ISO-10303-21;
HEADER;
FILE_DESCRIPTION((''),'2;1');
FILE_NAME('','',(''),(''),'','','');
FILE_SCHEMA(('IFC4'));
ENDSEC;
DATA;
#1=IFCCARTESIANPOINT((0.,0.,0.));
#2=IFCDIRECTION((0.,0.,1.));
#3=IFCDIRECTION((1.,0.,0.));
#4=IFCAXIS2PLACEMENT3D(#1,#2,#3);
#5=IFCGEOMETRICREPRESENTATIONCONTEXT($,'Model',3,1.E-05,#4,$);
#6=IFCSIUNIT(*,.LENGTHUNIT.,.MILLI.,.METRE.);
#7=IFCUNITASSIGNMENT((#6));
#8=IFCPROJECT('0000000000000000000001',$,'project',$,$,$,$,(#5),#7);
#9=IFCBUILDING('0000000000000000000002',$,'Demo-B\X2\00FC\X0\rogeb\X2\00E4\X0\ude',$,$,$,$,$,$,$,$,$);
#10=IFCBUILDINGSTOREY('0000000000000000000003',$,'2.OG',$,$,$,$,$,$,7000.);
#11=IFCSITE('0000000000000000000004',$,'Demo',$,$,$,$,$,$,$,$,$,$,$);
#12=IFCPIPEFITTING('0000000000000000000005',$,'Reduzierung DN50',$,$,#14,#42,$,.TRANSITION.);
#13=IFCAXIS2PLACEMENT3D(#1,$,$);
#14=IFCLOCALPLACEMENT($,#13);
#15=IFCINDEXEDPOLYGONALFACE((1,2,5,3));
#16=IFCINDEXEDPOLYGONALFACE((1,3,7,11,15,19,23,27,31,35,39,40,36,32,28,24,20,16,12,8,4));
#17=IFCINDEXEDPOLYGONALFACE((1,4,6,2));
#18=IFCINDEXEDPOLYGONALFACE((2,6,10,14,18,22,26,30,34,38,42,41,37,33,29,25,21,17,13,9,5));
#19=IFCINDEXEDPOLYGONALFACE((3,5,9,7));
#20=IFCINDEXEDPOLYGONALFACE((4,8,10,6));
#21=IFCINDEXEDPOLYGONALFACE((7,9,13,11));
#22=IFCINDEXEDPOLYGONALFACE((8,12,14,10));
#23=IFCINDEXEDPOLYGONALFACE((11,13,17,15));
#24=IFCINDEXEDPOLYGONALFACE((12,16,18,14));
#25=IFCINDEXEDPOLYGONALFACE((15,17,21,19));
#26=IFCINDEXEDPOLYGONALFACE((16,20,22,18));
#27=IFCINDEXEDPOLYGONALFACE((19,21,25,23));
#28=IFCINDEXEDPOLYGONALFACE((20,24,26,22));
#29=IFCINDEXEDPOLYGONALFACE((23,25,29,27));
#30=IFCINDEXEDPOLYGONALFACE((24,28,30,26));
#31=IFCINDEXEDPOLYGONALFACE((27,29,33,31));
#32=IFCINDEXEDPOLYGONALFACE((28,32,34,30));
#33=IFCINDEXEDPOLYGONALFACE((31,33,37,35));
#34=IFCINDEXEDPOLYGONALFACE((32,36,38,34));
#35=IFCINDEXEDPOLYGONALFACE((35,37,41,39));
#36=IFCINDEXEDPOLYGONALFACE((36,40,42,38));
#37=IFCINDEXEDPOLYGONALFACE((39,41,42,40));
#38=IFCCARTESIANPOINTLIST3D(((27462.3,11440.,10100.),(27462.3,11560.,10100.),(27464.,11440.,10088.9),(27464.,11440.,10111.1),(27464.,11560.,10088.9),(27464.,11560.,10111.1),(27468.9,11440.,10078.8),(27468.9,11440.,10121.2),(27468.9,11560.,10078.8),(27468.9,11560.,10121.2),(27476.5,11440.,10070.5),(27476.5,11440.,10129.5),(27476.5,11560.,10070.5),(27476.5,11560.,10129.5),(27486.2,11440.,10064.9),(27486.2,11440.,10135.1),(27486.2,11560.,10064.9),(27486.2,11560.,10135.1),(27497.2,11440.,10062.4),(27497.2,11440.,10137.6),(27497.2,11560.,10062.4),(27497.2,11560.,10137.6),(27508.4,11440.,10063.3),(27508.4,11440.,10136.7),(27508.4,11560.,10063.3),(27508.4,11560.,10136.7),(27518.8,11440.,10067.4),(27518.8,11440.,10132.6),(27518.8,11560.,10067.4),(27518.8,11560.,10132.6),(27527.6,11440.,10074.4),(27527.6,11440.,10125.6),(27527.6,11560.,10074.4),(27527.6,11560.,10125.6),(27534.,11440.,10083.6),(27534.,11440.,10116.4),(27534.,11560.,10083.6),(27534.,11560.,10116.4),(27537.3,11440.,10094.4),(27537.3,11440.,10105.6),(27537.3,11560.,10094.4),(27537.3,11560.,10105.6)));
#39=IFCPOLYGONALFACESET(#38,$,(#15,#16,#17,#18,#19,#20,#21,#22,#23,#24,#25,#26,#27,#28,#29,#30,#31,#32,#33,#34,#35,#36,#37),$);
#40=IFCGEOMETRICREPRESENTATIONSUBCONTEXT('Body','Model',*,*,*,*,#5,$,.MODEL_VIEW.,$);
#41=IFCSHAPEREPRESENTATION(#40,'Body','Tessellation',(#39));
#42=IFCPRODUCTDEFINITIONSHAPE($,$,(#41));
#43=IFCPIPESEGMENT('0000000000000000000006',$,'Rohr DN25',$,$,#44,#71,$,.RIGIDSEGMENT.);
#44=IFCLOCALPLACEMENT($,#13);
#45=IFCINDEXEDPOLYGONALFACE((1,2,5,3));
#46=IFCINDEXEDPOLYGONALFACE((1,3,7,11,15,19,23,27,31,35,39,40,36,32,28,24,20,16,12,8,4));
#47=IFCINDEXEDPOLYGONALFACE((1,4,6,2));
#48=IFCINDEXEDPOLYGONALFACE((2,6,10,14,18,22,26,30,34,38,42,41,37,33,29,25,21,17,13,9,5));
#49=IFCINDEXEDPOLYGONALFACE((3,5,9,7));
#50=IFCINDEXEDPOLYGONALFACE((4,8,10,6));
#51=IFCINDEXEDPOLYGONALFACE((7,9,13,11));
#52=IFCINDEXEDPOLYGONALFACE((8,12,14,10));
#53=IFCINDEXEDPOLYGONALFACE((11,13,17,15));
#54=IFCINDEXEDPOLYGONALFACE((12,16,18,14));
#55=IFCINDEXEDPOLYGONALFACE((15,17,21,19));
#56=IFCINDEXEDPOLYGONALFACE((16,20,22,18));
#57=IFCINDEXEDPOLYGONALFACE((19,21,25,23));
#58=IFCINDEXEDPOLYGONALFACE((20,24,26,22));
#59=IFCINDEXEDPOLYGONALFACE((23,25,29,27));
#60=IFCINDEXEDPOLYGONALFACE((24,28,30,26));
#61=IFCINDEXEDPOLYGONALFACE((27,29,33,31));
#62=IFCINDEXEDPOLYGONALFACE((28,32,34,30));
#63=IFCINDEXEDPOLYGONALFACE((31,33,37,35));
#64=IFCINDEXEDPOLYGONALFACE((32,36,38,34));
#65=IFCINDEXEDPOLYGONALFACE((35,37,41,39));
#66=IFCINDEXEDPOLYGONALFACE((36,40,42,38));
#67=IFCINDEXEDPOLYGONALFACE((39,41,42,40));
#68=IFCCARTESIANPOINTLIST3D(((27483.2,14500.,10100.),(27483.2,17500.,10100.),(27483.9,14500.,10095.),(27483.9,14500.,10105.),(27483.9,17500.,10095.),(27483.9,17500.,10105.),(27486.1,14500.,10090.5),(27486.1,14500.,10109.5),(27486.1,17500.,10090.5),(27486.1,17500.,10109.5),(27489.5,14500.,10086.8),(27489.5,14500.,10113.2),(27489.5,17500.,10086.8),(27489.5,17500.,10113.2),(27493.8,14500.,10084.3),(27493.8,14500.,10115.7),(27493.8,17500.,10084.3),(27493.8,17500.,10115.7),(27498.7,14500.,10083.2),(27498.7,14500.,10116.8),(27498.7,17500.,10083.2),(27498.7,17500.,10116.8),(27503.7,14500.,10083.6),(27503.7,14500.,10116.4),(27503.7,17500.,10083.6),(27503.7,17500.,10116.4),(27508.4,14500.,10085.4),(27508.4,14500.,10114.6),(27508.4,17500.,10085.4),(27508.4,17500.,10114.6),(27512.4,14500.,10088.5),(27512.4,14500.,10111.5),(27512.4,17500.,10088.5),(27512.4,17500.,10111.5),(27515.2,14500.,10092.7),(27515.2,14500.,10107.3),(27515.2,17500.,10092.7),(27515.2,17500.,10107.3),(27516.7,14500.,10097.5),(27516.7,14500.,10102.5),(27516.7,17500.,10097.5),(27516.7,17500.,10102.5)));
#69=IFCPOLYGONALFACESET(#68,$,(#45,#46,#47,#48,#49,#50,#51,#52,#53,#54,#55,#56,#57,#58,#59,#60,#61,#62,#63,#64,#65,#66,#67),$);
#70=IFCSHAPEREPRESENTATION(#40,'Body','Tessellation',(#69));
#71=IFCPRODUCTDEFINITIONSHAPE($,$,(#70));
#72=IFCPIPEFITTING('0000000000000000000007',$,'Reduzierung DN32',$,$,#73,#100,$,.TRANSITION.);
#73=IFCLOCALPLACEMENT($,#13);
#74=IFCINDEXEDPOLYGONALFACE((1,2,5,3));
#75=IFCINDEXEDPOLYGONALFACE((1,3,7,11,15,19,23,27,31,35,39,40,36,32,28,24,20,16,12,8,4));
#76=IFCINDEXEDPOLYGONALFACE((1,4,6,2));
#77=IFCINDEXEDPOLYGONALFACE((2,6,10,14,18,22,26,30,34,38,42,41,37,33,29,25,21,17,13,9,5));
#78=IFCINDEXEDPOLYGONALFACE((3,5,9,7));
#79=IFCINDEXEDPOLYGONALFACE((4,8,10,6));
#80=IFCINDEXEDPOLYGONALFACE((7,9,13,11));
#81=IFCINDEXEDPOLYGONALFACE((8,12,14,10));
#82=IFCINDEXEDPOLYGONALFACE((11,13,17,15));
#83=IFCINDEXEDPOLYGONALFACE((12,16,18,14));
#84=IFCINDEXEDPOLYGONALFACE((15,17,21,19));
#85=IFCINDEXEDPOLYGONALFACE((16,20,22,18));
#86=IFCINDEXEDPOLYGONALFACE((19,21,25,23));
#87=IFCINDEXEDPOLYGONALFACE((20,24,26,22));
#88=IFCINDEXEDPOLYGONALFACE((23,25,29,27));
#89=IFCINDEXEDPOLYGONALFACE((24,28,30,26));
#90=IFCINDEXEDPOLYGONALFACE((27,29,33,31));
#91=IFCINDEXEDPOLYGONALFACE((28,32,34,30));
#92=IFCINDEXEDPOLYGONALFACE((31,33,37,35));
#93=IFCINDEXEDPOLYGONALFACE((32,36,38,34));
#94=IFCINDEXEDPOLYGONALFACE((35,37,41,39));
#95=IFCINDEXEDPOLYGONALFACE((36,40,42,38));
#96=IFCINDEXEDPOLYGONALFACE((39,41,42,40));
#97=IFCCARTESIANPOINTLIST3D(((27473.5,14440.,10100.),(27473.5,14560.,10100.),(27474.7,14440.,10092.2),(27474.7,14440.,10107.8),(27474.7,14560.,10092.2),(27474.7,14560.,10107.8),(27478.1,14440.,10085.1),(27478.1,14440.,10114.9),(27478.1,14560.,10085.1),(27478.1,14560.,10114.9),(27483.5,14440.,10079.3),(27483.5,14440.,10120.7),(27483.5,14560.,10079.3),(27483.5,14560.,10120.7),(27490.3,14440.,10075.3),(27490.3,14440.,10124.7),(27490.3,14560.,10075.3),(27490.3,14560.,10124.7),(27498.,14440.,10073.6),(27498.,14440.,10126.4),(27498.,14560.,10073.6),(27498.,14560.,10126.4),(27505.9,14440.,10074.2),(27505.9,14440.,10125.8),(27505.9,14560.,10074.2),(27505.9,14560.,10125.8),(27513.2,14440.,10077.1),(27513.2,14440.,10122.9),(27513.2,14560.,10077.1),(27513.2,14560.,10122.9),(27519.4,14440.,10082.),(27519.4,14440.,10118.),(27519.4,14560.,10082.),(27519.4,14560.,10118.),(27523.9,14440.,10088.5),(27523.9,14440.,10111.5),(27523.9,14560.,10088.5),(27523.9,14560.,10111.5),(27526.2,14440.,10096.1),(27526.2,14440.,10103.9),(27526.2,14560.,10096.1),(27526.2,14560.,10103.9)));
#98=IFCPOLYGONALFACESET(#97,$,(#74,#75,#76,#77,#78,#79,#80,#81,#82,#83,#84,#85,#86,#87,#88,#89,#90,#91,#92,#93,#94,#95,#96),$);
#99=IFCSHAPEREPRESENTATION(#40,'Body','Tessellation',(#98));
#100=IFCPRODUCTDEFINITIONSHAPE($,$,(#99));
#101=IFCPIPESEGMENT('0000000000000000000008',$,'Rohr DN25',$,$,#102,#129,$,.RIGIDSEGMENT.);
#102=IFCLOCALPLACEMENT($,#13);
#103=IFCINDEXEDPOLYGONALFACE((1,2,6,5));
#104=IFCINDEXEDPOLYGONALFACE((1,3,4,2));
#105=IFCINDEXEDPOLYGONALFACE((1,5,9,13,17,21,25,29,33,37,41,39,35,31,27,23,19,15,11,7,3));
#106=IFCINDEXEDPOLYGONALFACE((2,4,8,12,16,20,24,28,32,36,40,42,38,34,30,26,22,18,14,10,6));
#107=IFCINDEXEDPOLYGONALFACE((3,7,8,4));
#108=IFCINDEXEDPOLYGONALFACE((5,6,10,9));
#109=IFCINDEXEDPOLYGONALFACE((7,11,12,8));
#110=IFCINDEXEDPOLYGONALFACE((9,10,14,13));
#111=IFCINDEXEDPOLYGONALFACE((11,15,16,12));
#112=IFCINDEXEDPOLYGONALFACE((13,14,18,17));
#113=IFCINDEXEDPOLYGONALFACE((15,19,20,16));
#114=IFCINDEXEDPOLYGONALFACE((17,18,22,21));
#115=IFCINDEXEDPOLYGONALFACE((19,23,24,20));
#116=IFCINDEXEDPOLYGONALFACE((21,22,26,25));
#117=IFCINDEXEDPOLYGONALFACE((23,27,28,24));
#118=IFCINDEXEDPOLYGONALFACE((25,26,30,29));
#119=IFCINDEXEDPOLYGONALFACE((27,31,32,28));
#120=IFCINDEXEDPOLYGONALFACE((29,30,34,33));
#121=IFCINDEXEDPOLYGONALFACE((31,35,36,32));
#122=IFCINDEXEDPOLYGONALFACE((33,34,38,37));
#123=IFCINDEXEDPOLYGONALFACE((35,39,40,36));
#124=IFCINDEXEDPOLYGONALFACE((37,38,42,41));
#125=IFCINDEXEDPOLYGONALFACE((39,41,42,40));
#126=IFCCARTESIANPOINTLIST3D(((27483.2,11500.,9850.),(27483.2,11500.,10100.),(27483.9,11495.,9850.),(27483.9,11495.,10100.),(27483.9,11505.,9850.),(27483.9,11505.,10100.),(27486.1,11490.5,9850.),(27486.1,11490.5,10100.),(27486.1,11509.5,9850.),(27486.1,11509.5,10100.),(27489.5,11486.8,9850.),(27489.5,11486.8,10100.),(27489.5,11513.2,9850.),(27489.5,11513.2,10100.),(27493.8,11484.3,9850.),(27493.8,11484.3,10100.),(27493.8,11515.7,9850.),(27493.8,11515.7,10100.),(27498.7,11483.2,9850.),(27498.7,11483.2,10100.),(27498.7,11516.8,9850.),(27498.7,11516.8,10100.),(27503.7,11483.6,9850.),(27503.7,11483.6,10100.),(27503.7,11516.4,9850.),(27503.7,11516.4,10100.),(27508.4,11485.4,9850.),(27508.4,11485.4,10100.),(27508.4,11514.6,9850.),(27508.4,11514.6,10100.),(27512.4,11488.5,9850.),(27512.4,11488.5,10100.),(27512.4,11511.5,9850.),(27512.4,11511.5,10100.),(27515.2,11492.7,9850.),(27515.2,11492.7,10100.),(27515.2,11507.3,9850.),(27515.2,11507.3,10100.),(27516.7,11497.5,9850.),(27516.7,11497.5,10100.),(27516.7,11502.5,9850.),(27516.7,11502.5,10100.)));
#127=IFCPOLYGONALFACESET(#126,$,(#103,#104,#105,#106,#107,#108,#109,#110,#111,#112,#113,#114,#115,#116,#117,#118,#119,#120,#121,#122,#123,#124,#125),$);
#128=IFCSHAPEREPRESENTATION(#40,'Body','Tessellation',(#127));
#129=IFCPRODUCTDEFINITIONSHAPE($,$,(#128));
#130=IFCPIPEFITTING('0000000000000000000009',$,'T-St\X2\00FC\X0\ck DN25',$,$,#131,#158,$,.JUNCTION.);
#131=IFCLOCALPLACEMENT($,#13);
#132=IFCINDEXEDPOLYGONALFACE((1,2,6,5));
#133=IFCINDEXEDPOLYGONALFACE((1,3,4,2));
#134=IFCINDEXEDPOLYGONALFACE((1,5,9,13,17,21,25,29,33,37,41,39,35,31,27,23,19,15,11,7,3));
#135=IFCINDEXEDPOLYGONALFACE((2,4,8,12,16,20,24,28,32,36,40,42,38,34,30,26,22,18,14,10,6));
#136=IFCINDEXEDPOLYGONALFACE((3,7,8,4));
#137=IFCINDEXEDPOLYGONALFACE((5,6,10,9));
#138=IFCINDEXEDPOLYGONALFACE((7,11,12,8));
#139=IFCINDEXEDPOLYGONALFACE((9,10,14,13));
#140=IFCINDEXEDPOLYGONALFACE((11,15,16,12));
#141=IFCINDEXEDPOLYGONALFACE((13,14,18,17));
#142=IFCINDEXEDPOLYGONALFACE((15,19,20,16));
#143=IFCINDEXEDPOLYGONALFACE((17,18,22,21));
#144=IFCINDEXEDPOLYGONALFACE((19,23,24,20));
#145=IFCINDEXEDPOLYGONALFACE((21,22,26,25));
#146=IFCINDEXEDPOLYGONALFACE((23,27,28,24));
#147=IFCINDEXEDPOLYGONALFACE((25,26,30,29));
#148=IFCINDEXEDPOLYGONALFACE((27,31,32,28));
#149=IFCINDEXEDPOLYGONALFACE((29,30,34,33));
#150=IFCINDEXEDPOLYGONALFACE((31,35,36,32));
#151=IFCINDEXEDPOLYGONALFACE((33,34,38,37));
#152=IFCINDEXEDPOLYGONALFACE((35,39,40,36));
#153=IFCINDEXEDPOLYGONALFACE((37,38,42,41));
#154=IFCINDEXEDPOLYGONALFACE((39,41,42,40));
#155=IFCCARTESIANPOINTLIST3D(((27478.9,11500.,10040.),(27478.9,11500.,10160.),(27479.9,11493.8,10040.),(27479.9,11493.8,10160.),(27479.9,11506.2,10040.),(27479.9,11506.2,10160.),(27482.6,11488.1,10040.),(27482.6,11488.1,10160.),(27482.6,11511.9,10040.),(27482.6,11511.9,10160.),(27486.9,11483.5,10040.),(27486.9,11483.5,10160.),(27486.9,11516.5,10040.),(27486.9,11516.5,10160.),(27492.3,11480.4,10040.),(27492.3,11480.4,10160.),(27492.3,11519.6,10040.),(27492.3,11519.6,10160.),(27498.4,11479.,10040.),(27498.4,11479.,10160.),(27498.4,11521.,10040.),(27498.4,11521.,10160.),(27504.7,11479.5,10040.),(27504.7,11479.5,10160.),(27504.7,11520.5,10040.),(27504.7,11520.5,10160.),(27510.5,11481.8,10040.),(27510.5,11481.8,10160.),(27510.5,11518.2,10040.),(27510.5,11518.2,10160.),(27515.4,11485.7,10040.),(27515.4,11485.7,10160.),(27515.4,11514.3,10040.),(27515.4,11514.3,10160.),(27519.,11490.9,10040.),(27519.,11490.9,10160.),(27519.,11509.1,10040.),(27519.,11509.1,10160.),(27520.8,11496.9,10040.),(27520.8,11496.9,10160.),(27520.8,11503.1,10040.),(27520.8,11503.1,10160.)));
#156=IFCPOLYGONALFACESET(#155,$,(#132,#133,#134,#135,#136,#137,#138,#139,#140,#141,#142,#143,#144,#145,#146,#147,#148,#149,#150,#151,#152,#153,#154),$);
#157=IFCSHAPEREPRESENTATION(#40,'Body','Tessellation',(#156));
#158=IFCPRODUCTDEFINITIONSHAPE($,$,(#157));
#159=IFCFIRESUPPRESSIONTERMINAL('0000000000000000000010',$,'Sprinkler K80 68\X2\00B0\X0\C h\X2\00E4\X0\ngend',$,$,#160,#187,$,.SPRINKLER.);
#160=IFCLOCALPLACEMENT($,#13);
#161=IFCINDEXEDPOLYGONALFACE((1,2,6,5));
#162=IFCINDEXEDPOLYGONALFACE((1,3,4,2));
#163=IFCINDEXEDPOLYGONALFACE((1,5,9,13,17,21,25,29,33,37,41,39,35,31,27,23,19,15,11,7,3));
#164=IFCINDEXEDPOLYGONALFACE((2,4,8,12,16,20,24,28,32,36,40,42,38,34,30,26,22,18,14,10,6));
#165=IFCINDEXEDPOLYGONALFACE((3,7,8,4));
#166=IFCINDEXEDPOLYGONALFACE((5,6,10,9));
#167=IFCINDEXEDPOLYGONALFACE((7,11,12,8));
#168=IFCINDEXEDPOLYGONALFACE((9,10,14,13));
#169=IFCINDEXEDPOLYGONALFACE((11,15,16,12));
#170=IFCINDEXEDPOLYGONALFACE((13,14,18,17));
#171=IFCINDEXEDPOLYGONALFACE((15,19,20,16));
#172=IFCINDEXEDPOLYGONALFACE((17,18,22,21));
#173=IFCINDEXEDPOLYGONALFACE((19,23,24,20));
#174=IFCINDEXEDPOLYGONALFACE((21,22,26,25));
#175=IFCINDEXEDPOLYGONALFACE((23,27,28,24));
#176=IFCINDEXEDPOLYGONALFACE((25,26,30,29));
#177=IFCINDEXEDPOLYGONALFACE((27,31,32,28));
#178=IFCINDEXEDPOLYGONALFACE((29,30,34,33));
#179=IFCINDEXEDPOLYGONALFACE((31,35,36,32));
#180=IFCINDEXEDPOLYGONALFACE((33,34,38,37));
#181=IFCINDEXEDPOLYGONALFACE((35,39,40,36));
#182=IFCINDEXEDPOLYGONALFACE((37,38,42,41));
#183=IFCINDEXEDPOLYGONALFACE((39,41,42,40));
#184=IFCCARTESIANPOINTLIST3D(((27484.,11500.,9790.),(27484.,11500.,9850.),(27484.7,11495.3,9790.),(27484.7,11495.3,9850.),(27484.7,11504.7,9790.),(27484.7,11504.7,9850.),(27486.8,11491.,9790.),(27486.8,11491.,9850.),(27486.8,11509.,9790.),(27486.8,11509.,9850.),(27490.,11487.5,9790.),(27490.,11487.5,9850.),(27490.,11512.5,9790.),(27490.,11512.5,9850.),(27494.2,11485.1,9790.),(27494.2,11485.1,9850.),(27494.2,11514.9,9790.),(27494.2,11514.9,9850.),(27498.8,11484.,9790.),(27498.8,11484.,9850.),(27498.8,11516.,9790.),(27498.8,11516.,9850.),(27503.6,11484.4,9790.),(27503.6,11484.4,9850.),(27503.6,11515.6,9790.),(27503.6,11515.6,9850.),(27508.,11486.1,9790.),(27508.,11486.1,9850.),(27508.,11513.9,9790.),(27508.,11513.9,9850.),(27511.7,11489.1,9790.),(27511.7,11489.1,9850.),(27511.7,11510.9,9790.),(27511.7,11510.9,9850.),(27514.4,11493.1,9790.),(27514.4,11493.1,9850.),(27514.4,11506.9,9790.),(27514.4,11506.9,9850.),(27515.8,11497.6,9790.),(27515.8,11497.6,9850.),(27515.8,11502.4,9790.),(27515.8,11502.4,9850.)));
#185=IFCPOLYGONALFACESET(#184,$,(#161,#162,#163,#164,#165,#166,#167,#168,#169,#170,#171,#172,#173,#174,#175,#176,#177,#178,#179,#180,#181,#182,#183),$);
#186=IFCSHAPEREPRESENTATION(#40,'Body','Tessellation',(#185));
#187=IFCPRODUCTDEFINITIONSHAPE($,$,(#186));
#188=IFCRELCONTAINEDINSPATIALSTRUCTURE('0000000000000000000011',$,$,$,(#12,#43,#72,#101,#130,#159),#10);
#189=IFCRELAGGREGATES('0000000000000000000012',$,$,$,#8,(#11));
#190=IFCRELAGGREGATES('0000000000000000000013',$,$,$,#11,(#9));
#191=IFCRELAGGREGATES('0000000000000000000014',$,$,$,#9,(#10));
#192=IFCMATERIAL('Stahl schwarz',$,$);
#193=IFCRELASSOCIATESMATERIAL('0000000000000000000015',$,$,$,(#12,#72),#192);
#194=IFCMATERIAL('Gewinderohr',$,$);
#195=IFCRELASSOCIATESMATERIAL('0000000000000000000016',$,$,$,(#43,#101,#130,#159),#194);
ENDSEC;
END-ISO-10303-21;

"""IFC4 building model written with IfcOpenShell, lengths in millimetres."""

from ifc_helpers import new_model, si_unit, frame, origin_with_axes, place, context, subcontext, project, spatial, circle, extrude, material, element, save


model = new_model("IFC4")

# Units and contexts
model_context = context("Model", 3, precision=1e-05, world=origin_with_axes())
body_context = subcontext(model_context, "Body", "Model", "MODEL_VIEW")
ifc_project = project(units=[si_unit("LENGTHUNIT", "METRE", prefix="MILLI")], contexts=[model_context])

# Site, building, storey
site = spatial("IfcSite", under=ifc_project, Name="Demo")
building = spatial("IfcBuilding", under=site, Name="Demo-Bürogebäude")
storey = spatial("IfcBuildingStorey", under=building, Name="2.OG", Elevation=7000.0)

# Shared definitions
ifc_material_1 = material(Name="Gewinderohr")

# Shared definitions
ifc_material_2 = material(Name="Stahl schwarz")

# Pipe fitting
pipe_fitting_1_placement = place(None, frame((27500.0, 11440.0, 10100.0), z_axis=(0.0, 1.0, 0.0), x_axis=(-1.0, 0.0, 0.0)))
element("IfcPipeFitting", 1, at=pipe_fitting_1_placement, inside=storey, material=ifc_material_2, Name="Reduzierung DN50", PredefinedType="TRANSITION", context=body_context, shape_type="SweptSolid", body=[
    extrude(circle(Radius=37.7), origin_with_axes(), (0.0, 0.0, 1.0), 120.0),
])

# Pipe segment
pipe_segment_1_placement = place(None, frame((27500.0, 14500.0, 10100.0), z_axis=(0.0, 1.0, 0.0), x_axis=(-1.0, 0.0, 0.0)))
element("IfcPipeSegment", 2, at=pipe_segment_1_placement, inside=storey, material=ifc_material_1, Name="Rohr DN25", PredefinedType="RIGIDSEGMENT", context=body_context, shape_type="SweptSolid", body=[
    extrude(circle(Radius=16.9), origin_with_axes(), (0.0, 0.0, 1.0), 3000.0),
])

# Pipe fitting
pipe_fitting_2_placement = place(None, frame((27500.0, 14440.0, 10100.0), z_axis=(0.0, 1.0, 0.0), x_axis=(-1.0, 0.0, 0.0)))
element("IfcPipeFitting", 3, at=pipe_fitting_2_placement, inside=storey, material=ifc_material_2, Name="Reduzierung DN32", PredefinedType="TRANSITION", context=body_context, shape_type="SweptSolid", body=[
    extrude(circle(Radius=26.5), origin_with_axes(), (0.0, 0.0, 1.0), 120.0),
])

# Pipe segment
pipe_segment_2_placement = place(None, frame((27500.0, 11500.0, 10100.0), z_axis=(0.0, 0.0, -1.0), x_axis=(-1.0, 0.0, 0.0)))
element("IfcPipeSegment", 4, at=pipe_segment_2_placement, inside=storey, material=ifc_material_1, Name="Rohr DN25", PredefinedType="RIGIDSEGMENT", context=body_context, shape_type="SweptSolid", body=[
    extrude(circle(Radius=16.9), origin_with_axes(), (0.0, 0.0, 1.0), 250.0),
])

# Pipe fitting
pipe_fitting_3_placement = place(None, frame((27500.0, 11500.0, 10160.0), z_axis=(0.0, 0.0, -1.0), x_axis=(-1.0, 0.0, 0.0)))
element("IfcPipeFitting", 5, at=pipe_fitting_3_placement, inside=storey, material=ifc_material_1, Name="T-Stück DN25", PredefinedType="JUNCTION", context=body_context, shape_type="SweptSolid", body=[
    extrude(circle(Radius=21.1), origin_with_axes(), (0.0, 0.0, 1.0), 120.0),
])

# Fire suppression terminal
fire_suppression_terminal_1_placement = place(None, frame((27500.0, 11500.0, 9850.0), z_axis=(0.0, 0.0, -1.0), x_axis=(-1.0, 0.0, 0.0)))
element("IfcFireSuppressionTerminal", 6, at=fire_suppression_terminal_1_placement, inside=storey, material=ifc_material_1, Name="Sprinkler K80 68°C hängend", PredefinedType="SPRINKLER", context=body_context, shape_type="SweptSolid", body=[
    extrude(circle(Radius=16.0), origin_with_axes(), (0.0, 0.0, 1.0), 60.0),
])

save(model, "model.ifc")
